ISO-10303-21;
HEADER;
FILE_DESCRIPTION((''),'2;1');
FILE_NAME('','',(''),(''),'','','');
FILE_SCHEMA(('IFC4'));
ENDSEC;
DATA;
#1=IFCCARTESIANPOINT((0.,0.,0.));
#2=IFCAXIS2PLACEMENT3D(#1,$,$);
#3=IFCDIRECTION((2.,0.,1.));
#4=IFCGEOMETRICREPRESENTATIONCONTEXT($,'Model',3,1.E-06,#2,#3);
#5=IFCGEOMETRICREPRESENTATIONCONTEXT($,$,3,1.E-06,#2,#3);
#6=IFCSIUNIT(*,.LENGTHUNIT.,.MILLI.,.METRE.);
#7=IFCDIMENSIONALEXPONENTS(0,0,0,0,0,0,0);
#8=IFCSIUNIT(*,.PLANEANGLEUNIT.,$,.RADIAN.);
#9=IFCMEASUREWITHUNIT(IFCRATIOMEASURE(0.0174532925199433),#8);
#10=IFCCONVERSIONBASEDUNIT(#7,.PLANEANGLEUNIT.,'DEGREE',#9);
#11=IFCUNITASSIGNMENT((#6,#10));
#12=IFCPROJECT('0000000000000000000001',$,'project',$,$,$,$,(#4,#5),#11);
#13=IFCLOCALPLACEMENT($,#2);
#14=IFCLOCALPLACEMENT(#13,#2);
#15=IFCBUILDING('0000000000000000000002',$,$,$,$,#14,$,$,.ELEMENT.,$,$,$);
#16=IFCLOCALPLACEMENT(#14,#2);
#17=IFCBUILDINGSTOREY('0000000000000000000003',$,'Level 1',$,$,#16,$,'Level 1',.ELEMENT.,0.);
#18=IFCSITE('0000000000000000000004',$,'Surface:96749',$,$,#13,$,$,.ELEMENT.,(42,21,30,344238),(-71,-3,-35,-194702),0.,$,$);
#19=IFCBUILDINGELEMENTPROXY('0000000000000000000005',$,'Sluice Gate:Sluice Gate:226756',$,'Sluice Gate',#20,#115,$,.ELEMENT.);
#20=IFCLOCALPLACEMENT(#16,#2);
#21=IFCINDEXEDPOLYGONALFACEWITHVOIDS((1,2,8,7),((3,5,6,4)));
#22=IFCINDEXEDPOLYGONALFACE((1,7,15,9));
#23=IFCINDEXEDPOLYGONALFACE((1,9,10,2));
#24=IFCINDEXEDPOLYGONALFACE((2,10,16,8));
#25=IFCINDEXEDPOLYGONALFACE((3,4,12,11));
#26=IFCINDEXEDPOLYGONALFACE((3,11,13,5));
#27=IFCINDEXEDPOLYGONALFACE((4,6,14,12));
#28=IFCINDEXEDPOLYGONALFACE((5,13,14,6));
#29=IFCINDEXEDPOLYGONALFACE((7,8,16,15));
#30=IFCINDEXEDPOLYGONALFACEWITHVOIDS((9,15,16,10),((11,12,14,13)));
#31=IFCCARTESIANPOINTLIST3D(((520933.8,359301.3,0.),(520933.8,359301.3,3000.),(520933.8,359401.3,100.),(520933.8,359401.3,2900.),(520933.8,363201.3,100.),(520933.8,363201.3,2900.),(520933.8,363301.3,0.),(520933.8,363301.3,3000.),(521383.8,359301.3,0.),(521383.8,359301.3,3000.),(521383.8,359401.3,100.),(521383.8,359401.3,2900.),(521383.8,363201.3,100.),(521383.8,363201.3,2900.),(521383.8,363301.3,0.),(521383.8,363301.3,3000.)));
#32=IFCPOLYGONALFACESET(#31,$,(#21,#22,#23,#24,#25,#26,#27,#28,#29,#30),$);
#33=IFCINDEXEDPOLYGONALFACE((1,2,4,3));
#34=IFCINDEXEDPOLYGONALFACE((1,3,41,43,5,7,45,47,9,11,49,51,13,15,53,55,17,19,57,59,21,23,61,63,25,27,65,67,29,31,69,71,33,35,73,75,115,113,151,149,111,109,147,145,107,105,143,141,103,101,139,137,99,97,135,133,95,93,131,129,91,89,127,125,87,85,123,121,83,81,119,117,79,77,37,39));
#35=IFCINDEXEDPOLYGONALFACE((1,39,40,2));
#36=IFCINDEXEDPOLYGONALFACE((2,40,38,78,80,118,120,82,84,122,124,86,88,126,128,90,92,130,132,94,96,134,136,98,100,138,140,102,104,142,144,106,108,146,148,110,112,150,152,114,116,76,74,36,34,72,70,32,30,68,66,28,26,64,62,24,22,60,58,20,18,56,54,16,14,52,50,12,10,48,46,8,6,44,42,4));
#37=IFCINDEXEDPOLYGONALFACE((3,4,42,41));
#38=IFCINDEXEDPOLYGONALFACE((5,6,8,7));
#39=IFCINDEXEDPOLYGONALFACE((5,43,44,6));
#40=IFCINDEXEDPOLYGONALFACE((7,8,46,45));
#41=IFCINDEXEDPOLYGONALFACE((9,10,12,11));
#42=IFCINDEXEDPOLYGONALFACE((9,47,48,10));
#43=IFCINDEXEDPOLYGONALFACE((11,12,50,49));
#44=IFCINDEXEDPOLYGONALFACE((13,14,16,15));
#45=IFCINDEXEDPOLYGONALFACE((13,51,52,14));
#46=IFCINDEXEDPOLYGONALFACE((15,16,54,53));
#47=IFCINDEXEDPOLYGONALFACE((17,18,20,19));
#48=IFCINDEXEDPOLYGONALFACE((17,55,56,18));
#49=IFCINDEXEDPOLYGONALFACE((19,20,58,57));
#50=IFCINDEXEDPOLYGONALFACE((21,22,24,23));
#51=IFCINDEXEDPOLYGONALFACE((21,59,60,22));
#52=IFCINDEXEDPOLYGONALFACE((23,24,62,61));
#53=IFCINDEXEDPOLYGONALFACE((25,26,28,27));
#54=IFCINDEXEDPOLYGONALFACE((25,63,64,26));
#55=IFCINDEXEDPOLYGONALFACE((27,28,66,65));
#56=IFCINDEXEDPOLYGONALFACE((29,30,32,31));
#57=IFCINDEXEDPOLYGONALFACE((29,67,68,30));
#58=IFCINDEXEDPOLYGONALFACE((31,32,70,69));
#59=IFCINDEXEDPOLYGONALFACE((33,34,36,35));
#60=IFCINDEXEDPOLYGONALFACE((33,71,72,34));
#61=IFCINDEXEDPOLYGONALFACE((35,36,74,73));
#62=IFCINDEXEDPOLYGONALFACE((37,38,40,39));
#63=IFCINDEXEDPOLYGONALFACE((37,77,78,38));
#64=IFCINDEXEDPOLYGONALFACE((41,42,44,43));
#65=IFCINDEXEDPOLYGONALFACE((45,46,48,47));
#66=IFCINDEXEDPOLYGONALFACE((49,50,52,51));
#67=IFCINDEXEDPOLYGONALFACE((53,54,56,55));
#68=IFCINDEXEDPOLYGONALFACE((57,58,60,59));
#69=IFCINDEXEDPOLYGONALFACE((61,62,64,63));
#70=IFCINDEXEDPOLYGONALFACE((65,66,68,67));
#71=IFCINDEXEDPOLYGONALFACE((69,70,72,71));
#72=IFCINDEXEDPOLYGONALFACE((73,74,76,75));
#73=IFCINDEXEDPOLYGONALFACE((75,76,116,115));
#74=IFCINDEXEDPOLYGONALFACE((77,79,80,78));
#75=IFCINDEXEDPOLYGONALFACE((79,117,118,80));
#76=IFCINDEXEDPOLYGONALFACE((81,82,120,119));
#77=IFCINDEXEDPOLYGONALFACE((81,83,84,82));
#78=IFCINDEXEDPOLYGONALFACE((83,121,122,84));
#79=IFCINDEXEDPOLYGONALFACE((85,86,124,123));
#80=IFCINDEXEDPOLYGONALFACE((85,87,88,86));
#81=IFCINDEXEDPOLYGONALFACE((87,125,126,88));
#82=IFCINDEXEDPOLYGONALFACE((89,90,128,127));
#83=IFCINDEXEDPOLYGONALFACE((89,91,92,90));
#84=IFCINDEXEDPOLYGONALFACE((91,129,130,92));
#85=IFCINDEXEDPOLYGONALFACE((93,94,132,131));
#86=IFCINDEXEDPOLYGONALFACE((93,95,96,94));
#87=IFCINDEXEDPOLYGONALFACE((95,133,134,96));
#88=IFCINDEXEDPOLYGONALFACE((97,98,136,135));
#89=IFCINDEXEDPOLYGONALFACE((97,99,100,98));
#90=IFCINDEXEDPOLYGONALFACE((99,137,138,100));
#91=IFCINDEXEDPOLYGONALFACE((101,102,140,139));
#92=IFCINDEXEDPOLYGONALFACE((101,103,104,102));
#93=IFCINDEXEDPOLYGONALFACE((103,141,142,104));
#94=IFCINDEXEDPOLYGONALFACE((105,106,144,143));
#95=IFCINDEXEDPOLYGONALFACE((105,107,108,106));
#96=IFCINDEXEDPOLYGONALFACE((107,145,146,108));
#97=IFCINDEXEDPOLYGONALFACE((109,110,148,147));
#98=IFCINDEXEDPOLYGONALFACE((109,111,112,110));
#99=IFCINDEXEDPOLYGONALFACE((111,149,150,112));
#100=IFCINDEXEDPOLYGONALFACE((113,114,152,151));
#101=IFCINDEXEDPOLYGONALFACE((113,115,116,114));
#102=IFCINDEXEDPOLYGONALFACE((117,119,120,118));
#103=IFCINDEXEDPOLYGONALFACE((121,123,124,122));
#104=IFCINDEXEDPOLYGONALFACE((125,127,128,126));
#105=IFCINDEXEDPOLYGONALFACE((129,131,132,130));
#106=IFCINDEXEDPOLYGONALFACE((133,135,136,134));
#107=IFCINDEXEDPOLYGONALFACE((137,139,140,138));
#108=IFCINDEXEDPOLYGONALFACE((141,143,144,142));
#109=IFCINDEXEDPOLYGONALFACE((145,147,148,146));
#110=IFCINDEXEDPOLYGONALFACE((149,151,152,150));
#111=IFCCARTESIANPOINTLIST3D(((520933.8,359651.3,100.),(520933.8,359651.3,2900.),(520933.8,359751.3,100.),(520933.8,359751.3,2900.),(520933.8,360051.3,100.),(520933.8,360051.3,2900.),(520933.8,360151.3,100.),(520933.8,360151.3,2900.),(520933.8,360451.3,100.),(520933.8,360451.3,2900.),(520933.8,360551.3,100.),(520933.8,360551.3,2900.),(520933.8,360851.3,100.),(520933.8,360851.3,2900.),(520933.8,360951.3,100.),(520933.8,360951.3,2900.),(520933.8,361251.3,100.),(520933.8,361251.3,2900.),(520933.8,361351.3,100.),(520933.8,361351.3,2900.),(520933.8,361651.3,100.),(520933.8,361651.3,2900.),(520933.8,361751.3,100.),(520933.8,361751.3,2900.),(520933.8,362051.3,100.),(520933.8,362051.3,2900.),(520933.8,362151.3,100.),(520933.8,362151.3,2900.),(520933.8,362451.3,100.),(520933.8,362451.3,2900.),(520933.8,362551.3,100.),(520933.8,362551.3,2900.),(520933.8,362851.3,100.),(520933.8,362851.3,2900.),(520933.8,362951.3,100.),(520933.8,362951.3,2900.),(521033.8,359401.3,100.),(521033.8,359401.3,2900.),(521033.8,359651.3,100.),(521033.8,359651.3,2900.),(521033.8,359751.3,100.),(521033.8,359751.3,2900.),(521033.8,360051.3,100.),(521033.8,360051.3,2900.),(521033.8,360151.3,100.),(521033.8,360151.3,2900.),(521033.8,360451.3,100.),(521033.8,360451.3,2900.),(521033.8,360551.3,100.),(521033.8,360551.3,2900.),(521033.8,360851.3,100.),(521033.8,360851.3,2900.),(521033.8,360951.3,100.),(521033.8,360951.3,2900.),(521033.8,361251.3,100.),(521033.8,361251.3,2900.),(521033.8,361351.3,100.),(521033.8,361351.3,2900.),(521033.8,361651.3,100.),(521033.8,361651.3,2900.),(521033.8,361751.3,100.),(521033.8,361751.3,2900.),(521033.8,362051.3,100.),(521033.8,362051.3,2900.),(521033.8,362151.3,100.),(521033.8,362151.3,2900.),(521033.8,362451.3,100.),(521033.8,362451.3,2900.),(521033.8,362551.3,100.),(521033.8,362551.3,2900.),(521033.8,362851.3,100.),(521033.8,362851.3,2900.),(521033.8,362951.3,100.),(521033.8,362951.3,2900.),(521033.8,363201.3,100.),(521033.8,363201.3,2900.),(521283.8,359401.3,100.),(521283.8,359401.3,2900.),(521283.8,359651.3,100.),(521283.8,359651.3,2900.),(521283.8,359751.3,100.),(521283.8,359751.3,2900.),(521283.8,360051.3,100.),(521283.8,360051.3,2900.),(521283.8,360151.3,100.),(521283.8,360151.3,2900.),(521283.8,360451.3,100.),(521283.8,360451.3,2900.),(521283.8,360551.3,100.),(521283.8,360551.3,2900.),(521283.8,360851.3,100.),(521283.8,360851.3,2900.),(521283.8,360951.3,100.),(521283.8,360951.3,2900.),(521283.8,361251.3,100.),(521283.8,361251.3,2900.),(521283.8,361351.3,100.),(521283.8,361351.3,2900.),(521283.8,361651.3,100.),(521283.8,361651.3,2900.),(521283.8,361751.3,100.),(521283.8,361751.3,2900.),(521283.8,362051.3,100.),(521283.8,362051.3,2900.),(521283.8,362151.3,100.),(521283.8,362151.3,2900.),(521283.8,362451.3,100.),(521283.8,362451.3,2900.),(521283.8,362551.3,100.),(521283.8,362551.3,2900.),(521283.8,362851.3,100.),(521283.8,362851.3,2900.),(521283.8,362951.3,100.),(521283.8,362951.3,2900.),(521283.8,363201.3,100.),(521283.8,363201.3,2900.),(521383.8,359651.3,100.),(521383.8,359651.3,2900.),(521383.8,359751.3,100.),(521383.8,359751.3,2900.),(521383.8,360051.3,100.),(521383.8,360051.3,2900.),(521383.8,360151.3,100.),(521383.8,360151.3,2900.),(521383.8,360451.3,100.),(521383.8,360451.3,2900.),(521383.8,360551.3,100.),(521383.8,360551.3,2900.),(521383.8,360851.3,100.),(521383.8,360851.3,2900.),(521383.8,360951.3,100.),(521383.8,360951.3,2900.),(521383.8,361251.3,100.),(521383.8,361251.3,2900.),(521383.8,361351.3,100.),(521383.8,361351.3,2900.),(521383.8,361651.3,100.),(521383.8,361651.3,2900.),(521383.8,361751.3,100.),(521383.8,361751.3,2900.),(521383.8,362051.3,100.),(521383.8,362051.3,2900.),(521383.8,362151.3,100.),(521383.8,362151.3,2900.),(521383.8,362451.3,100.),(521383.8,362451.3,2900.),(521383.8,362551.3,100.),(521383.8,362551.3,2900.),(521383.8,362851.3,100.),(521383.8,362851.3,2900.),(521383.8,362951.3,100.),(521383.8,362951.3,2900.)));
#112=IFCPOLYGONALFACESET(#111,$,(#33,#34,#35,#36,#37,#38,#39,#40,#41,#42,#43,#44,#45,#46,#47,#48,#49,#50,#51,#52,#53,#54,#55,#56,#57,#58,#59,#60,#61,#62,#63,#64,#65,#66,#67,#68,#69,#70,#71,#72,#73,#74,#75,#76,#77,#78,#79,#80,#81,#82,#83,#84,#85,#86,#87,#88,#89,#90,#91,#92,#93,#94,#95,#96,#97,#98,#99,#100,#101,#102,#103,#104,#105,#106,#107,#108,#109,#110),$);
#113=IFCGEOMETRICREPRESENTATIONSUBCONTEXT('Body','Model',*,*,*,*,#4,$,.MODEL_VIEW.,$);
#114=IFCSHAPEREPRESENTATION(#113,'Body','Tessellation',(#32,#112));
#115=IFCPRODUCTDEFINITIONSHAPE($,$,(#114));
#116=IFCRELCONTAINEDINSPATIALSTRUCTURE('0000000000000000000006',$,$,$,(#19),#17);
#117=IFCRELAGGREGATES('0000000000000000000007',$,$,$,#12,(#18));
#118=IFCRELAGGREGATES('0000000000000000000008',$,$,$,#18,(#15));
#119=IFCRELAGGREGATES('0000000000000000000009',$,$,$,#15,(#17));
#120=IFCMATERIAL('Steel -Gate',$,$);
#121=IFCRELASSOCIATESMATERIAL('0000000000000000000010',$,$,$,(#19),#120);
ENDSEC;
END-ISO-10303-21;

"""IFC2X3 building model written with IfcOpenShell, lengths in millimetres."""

from ifc_helpers import new_model, entity, si_unit, converted_unit, direction, frame, origin, place, context, subcontext, project, spatial, polyline, outline, extrude, source, transform, mapped, material, element, save


model = new_model("IFC2X3")

# Units and contexts
model_context = context("Model", 3, precision=1e-06, world=origin(), true_north=direction((2.0, 0.0, 1.0)))
context_of_model = context(None, 3, precision=1e-06, world=origin(), true_north=direction((2.0, 0.0, 1.0)))
body_context = subcontext(model_context, "Body", "Model", "MODEL_VIEW")
ifc_project = project(units=[si_unit("LENGTHUNIT", "METRE", prefix="MILLI"), converted_unit("PLANEANGLEUNIT", "DEGREE", entity("IfcRatioMeasure", 0.0174532925199433), si_unit("PLANEANGLEUNIT", "RADIAN"), dimensions=[0, 0, 0, 0, 0, 0, 0])], contexts=[model_context, context_of_model])

# Site, building, storey
site_placement = place(None, origin())
site = spatial("IfcSite", under=ifc_project, at=site_placement, Name="Surface:96749", CompositionType="ELEMENT", RefLatitude=(42, 21, 30, 344238), RefLongitude=(-71, -3, -35, -194702), RefElevation=0.0)
building_placement = place(site_placement, origin())
building = spatial("IfcBuilding", under=site, at=building_placement, CompositionType="ELEMENT")
storey_placement = place(building_placement, origin())
storey = spatial("IfcBuildingStorey", under=building, at=storey_placement, Name="Level 1", LongName="Level 1", CompositionType="ELEMENT", Elevation=0.0)

# Building element proxy
ifc_material = material(Name="Steel -Gate")
shared_shape_1 = source(origin(), body_context, "Body", "SweptSolid", [
    extrude(outline(polyline([(-1500.0, -2000.0), (1500.0, -2000.0), (1500.0, 2000.0), (-1500.0, 2000.0), (-1500.0, -2000.0)]), holes=[polyline([(1400.0, -1900.0), (-1400.0, -1900.0), (-1400.0, 1900.0), (1400.0, 1900.0), (1400.0, -1900.0)])]), frame((0.0, -225.0, 1500.0), z_axis=(0.0, 1.0, 0.0), x_axis=(0.0, 0.0, -1.0)), (0.0, 0.0, 1.0), 450.0),
    extrude(outline(polyline([(1650.0, -125.0), (1900.0, -125.0), (1900.0, 125.0), (1650.0, 125.0), (1650.0, 225.0), (1550.0, 225.0), (1550.0, 125.0), (1250.0, 125.0), (1250.0, 225.0), (1150.0, 225.0), (1150.0, 125.0), (850.0, 125.0), (850.0, 225.0), (750.0, 225.0), (750.0, 125.0), (450.0, 125.0), (450.0, 225.0), (350.0, 225.0), (350.0, 125.0), (50.0, 125.0), (50.0, 225.0), (-50.0, 225.0), (-50.0, 125.0), (-350.0, 125.0), (-350.0, 225.0), (-450.0, 225.0), (-450.0, 125.0), (-750.0, 125.0), (-750.0, 225.0), (-850.0, 225.0), (-850.0, 125.0), (-1150.0, 125.0), (-1150.0, 225.0), (-1250.0, 225.0), (-1250.0, 125.0), (-1550.0, 125.0), (-1550.0, 225.0), (-1650.0, 225.0), (-1650.0, 125.0), (-1900.0, 125.0), (-1900.0, -125.0), (-1650.0, -125.0), (-1650.0, -225.0), (-1550.0, -225.0), (-1550.0, -125.0), (-1250.0, -125.0), (-1250.0, -225.0), (-1150.0, -225.0), (-1150.0, -125.0), (-850.0, -125.0), (-850.0, -225.0), (-750.0, -225.0), (-750.0, -125.0), (-450.0, -125.0), (-450.0, -225.0), (-350.0, -225.0), (-350.0, -125.0), (-50.0, -125.0), (-50.0, -225.0), (50.0, -225.0), (50.0, -125.0), (350.0, -125.0), (350.0, -225.0), (450.0, -225.0), (450.0, -125.0), (750.0, -125.0), (750.0, -225.0), (850.0, -225.0), (850.0, -125.0), (1150.0, -125.0), (1150.0, -225.0), (1250.0, -225.0), (1250.0, -125.0), (1550.0, -125.0), (1550.0, -225.0), (1650.0, -225.0), (1650.0, -125.0)])), frame((0.0, 0.0, 100.0), z_axis=(0.0, 0.0, 1.0), x_axis=(-1.0, 0.0, 0.0)), (0.0, 0.0, 1.0), 2800.0),
])
for number, where, z_axis, x_axis, name in (
    (1, (521158.8, 361301.3, 0.0), (0.0, 0.0, 1.0), (0.0, 1.0, 0.0), "Sluice Gate:Sluice Gate:226756"),
):
    element("IfcBuildingElementProxy", number, at=place(storey_placement, frame(where, z_axis=z_axis, x_axis=x_axis)), inside=storey, material=ifc_material, Name=name, ObjectType="Sluice Gate", CompositionType="ELEMENT", context=body_context, shape_type="MappedRepresentation", body=[
        mapped(shared_shape_1, transform((0.0, 0.0, 0.0), scale=1.0)),
    ])

save(model, "model.ifc")
